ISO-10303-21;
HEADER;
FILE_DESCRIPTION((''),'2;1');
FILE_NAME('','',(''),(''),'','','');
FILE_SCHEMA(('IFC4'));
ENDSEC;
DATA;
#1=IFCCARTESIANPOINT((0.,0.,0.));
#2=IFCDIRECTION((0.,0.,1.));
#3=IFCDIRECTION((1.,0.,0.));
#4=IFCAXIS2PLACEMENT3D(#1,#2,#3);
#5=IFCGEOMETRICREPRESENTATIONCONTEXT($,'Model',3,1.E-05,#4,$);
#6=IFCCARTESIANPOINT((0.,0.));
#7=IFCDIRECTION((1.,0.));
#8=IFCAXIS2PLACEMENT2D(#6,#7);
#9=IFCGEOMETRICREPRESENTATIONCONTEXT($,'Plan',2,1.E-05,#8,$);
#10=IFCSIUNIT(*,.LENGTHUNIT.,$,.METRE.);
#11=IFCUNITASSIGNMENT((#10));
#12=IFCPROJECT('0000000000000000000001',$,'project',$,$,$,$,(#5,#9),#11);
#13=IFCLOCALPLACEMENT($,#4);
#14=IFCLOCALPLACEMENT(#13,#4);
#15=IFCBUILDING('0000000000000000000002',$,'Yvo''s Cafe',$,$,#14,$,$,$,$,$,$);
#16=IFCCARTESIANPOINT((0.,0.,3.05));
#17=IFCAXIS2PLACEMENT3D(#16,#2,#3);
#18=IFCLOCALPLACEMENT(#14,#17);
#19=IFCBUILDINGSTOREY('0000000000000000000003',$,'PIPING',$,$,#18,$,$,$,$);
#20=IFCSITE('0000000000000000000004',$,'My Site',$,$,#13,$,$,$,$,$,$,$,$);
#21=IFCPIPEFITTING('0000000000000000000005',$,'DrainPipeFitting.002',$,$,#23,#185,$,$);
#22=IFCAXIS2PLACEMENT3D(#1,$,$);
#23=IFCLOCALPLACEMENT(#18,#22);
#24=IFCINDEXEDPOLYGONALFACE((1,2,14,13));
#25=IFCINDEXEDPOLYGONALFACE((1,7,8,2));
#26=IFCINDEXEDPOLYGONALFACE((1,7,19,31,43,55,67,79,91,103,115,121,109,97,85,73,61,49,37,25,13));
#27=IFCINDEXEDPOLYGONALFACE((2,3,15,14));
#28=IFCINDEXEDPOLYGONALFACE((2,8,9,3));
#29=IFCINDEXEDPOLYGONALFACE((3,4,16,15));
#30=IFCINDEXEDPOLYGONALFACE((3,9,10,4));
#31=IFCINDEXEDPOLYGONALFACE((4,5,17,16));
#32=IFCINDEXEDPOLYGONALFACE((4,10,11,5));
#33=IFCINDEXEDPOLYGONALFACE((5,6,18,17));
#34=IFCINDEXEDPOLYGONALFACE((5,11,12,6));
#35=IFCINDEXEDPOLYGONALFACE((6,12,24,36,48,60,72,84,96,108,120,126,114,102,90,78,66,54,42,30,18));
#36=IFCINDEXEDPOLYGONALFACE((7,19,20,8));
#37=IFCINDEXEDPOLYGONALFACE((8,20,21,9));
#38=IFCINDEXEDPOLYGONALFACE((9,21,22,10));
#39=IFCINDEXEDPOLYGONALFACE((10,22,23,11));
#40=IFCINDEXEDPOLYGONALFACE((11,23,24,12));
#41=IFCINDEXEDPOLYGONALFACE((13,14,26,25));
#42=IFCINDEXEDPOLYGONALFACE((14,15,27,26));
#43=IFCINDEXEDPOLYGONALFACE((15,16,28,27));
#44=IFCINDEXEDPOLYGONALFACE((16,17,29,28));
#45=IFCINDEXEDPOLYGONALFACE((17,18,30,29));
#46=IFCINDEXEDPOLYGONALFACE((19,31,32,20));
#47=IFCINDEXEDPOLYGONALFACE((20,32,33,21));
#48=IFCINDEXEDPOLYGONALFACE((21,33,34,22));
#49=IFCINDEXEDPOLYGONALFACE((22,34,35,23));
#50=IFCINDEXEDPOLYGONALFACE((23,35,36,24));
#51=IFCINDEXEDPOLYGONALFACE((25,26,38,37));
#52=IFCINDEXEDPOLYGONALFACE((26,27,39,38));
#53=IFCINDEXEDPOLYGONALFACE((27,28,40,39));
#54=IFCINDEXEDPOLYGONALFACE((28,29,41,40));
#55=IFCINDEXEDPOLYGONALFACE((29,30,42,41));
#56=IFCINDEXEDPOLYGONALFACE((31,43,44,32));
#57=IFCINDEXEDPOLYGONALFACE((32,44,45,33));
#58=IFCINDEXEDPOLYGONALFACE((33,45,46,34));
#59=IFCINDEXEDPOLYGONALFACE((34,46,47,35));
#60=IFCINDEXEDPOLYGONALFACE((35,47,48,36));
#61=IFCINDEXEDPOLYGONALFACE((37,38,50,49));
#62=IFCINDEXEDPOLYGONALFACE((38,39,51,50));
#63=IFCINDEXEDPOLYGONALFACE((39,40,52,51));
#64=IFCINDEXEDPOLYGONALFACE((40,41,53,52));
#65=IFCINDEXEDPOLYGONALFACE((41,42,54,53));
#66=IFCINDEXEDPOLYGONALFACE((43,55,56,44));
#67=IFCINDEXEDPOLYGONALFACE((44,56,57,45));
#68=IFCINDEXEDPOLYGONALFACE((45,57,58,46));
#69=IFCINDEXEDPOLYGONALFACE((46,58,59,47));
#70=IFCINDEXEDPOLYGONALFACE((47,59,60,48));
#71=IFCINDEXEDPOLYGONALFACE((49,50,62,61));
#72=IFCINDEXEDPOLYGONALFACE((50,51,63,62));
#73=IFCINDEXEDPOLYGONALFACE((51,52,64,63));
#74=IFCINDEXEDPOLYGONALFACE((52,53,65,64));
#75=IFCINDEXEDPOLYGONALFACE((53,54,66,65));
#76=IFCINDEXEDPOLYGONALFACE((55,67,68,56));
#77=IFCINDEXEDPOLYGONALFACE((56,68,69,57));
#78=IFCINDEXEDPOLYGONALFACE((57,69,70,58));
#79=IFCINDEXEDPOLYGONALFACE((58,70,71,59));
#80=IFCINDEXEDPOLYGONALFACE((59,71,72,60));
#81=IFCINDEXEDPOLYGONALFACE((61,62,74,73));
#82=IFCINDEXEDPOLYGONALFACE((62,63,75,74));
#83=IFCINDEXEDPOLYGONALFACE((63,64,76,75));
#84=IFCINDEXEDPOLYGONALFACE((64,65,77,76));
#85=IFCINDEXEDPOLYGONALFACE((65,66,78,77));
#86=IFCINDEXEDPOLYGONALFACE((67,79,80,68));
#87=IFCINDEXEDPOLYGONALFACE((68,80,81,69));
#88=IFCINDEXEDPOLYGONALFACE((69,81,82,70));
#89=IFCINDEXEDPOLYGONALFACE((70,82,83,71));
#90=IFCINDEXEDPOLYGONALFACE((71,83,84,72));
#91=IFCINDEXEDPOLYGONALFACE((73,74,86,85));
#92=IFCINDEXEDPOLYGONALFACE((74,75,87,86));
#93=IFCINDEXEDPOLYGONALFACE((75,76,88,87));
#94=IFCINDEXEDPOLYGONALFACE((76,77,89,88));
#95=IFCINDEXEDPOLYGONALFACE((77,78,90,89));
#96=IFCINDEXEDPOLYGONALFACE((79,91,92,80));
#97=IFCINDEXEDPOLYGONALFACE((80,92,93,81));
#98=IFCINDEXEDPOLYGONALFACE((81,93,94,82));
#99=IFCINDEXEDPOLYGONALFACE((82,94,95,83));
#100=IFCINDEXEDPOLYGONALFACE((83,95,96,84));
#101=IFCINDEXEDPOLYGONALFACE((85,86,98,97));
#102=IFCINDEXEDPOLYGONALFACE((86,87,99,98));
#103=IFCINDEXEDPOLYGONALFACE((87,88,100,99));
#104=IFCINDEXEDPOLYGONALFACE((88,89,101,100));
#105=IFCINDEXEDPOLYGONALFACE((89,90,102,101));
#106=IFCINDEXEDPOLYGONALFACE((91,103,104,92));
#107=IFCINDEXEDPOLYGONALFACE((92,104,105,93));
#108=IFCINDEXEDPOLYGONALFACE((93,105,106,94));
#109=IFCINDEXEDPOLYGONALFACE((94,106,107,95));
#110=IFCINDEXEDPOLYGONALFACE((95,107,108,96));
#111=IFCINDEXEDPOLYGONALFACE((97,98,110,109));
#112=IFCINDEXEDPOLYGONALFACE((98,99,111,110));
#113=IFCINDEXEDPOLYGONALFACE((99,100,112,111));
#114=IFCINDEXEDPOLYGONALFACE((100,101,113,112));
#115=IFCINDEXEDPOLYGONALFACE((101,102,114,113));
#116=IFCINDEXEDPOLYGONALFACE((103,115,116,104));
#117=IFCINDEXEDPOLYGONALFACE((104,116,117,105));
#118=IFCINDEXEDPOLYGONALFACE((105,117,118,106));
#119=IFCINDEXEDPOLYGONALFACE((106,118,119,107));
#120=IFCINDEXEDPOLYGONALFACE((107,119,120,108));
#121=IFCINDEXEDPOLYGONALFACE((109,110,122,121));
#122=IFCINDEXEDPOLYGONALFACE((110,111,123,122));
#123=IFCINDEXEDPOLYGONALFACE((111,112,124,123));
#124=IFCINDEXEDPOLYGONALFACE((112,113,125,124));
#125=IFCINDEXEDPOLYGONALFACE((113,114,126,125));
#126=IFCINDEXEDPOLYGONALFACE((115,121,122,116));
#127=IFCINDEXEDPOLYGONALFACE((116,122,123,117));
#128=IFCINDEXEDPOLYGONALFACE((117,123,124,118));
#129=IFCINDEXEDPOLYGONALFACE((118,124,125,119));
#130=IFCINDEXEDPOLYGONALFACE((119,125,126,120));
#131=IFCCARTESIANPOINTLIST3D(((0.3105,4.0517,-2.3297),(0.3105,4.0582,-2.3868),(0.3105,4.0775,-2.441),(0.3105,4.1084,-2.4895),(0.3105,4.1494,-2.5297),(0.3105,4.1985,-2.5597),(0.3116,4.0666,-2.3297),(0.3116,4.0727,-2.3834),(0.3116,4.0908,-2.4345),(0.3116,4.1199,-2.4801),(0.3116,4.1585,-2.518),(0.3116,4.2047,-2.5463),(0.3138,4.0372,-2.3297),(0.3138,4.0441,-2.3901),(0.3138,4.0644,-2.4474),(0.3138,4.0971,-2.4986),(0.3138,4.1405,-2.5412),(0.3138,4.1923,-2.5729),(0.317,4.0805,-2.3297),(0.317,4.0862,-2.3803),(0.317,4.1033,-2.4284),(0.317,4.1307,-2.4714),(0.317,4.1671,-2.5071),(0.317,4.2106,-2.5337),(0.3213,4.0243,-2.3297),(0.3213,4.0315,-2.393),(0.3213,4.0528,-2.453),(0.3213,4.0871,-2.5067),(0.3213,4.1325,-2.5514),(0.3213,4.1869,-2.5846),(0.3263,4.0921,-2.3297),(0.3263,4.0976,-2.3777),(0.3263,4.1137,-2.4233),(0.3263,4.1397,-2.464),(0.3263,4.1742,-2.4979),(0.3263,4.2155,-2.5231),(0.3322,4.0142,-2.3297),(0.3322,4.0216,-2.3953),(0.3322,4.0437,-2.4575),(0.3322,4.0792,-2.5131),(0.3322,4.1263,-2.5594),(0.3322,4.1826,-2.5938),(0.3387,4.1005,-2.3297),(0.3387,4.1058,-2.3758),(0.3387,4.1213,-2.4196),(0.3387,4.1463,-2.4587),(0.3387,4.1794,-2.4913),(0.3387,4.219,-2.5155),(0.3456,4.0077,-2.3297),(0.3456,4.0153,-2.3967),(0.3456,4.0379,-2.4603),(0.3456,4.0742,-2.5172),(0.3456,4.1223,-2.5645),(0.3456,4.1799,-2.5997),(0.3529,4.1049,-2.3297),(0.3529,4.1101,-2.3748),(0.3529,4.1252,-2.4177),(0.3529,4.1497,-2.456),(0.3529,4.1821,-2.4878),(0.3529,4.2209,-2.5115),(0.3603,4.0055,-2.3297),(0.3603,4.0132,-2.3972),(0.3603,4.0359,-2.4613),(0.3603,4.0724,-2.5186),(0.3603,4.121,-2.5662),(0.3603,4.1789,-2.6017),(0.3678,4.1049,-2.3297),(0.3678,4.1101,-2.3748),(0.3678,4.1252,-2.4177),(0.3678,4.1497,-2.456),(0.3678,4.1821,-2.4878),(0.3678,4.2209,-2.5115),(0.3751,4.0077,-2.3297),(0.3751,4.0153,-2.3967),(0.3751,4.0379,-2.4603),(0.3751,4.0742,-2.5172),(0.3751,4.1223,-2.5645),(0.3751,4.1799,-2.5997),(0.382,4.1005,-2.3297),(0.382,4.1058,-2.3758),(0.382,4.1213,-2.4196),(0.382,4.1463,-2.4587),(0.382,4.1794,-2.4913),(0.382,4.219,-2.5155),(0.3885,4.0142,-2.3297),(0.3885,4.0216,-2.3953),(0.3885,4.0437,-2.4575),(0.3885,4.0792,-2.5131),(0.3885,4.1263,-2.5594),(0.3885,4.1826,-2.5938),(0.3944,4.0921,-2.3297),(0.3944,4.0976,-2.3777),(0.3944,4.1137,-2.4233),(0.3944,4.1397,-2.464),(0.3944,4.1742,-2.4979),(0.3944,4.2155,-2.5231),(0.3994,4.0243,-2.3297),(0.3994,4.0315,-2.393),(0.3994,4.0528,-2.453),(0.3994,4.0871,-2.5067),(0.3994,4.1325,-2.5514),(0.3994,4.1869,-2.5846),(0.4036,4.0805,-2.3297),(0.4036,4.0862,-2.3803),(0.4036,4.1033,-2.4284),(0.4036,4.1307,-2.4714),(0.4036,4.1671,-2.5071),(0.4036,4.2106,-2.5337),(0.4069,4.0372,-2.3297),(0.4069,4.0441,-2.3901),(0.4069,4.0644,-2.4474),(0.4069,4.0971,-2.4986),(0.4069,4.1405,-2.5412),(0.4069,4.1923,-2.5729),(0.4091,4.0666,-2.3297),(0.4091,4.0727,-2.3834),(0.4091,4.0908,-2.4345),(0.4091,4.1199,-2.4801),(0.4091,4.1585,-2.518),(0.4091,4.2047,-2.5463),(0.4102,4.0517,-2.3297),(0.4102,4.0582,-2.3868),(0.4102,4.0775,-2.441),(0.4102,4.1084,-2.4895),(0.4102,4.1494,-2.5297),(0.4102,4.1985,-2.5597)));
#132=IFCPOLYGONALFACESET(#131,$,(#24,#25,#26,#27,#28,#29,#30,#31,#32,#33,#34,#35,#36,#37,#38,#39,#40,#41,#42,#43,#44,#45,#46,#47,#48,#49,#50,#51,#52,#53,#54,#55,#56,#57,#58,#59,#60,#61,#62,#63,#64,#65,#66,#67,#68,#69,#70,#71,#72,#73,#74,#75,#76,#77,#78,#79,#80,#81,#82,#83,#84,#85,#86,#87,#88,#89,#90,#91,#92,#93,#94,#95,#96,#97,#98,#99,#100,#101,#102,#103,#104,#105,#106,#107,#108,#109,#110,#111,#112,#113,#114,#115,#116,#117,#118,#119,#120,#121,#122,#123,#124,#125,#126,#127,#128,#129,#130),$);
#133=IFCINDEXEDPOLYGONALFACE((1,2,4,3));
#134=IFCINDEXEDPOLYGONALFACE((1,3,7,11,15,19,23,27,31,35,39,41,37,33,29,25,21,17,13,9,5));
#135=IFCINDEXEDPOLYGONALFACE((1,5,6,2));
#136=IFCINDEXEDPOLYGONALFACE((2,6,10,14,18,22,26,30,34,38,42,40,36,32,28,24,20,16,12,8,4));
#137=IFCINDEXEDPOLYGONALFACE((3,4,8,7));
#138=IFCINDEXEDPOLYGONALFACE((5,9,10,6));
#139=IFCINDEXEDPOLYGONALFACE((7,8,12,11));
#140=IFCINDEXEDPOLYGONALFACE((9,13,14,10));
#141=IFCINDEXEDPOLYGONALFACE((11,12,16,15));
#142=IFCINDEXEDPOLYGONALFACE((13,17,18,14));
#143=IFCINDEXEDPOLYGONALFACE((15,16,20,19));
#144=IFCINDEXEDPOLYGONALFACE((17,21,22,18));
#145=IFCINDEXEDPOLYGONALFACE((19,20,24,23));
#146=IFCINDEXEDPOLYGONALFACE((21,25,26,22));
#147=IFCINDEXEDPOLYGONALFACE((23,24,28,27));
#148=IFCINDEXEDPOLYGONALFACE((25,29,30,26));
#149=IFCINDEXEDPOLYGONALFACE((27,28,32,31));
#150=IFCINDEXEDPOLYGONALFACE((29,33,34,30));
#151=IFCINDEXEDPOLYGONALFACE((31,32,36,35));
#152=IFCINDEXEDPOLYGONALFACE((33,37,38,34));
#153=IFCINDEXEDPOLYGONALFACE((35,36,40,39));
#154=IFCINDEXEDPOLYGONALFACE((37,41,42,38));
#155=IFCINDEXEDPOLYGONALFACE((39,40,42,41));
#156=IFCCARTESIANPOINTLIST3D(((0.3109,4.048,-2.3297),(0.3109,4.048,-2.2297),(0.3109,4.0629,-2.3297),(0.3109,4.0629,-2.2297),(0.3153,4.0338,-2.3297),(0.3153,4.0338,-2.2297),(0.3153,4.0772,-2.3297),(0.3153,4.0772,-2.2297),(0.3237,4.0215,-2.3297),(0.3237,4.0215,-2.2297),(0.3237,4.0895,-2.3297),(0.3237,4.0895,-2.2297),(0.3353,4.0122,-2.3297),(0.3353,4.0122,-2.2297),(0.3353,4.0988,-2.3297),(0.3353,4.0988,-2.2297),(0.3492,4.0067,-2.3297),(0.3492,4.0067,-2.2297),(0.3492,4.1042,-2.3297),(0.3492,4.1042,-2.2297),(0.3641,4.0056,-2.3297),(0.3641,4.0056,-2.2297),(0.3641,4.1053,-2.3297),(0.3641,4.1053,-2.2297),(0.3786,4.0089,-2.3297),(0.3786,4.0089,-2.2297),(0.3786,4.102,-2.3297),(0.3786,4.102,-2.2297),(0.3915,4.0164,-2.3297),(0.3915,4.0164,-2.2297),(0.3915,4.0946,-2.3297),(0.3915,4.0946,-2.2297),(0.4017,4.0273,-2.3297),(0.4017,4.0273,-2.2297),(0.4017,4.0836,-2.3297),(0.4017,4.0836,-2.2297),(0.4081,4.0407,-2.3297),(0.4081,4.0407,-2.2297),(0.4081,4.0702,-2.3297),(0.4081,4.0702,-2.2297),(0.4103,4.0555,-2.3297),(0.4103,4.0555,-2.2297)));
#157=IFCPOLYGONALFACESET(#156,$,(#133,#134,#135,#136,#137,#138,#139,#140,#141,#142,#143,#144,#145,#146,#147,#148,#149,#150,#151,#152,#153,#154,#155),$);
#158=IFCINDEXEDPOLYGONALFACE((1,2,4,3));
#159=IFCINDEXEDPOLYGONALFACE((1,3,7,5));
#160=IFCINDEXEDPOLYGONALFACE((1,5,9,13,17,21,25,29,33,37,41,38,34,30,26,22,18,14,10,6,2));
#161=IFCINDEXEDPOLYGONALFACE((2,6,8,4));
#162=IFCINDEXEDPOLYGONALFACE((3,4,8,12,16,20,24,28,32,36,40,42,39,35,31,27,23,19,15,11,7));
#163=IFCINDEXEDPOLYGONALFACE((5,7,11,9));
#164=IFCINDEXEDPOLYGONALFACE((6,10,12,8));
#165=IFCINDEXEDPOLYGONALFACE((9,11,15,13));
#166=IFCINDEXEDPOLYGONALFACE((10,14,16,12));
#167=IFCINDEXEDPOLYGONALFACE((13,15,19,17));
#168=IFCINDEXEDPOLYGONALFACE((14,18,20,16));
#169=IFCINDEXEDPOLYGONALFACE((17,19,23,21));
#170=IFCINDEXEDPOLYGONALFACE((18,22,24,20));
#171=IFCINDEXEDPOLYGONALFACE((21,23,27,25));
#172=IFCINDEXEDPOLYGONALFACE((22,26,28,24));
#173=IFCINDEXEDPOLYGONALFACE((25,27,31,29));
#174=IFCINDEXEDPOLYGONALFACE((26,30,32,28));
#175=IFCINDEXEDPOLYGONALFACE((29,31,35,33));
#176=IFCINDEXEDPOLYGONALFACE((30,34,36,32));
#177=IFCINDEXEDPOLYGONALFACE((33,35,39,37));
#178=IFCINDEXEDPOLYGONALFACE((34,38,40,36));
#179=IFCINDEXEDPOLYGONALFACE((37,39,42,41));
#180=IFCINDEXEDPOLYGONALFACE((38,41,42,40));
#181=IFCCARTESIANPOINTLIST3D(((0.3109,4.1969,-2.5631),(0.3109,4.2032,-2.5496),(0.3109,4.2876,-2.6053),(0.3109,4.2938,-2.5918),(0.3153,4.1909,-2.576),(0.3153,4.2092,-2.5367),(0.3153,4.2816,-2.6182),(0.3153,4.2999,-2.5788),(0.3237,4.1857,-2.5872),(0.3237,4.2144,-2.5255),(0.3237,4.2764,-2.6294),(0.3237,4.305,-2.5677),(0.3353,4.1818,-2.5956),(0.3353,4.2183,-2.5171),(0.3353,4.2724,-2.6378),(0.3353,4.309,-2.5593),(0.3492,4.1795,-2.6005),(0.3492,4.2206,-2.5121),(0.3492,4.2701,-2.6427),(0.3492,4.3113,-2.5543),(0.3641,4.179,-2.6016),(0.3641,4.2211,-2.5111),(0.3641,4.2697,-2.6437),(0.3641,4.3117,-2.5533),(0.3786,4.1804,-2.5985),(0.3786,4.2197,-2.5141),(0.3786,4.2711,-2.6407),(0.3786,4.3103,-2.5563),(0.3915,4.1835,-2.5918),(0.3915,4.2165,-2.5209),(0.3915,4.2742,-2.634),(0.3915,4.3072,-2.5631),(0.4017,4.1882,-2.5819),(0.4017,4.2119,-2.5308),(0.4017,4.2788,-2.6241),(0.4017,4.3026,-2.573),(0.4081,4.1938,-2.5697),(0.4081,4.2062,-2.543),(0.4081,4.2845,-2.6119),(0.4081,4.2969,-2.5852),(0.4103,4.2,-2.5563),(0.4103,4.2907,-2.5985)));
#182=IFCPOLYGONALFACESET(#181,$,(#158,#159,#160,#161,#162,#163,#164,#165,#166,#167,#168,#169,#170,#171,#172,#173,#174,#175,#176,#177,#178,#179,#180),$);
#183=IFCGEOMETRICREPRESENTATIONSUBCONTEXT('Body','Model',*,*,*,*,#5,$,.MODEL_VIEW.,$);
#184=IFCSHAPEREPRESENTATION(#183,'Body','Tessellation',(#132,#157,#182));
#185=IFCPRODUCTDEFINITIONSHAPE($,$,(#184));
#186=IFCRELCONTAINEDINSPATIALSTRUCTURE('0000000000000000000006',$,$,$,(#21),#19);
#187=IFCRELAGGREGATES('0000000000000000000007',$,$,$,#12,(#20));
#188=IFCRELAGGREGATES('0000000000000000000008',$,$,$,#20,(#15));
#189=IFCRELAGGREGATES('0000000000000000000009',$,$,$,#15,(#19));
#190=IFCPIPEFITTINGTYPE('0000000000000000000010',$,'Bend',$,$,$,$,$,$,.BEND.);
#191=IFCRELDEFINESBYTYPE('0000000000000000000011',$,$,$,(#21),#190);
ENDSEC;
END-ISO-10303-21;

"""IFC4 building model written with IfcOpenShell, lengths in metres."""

from ifc_helpers import new_model, entity, si_unit, frame, origin_with_axes, origin_2d_with_axis, place, context, subcontext, project, spatial, circle, extrude, source, transform, mapped, type_object, type_shapes, element, save


model = new_model("IFC4")

# Units and contexts
model_context = context("Model", 3, precision=1e-05, world=origin_with_axes())
plan_context = context("Plan", 2, precision=1e-05, world=origin_2d_with_axis())
body_context = subcontext(model_context, "Body", "Model", "MODEL_VIEW")
ifc_project = project(units=[si_unit("LENGTHUNIT", "METRE")], contexts=[model_context, plan_context])

# Site, building, storey
site_placement = place(None, origin_with_axes())
site = spatial("IfcSite", under=ifc_project, at=site_placement, Name="My Site")
building_placement = place(site_placement, origin_with_axes())
building = spatial("IfcBuilding", under=site, at=building_placement, Name="Yvo's Cafe")
storey_placement = place(building_placement, frame((0.0, 0.0, 3.05), z_axis=(0.0, 0.0, 1.0), x_axis=(1.0, 0.0, 0.0)))
storey = spatial("IfcBuildingStorey", under=building, at=storey_placement, Name="PIPING")

# Pipe fitting
pipe_fitting_type_1 = type_object("IfcPipeFittingType", Name="Bend", PredefinedType="BEND")
shared_shape_1 = source(origin_with_axes(), body_context, "Body", "SolidModel", [
    entity("IfcSweptDiskSolid", entity("IfcIndexedPolyCurve", entity("IfcCartesianPointList3D", [[0.0, 0.0, 0.1], [0.0, -0.0392, 0.2344], [0.0, -0.1446, 0.3267]]), [entity("IfcArcIndex", [1, 2, 3])]), 0.05),
    extrude(circle(Radius=0.05), origin_with_axes(), (0.0, 0.0, 1.0), 0.1),
    extrude(circle(Radius=0.05), frame((0.0, -0.1446, 0.3267), z_axis=(0.0, -0.906711, 0.421751), x_axis=(1.0, 0.0, 0.0)), (0.0, 0.0, 1.0), 0.1),
])
type_shapes(pipe_fitting_type_1, [shared_shape_1])
pipe_fitting_1_placement = place(storey_placement, frame((0.3603, 4.0555, -2.2297), z_axis=(0.0, 0.0, -1.0), x_axis=(1.0, 0.0, 0.0)))
element("IfcPipeFitting", 1, at=pipe_fitting_1_placement, inside=storey, type_object=pipe_fitting_type_1, Name="DrainPipeFitting.002", context=body_context, shape_type="MappedRepresentation", body=[
    mapped(shared_shape_1, transform((0.0, 0.0, 0.0), x_axis=(1.0, 0.0, 0.0), y_axis=(0.0, 1.0, 0.0), z_axis=(0.0, 0.0, 1.0), scale=1.0)),
])

save(model, "model.ifc")
